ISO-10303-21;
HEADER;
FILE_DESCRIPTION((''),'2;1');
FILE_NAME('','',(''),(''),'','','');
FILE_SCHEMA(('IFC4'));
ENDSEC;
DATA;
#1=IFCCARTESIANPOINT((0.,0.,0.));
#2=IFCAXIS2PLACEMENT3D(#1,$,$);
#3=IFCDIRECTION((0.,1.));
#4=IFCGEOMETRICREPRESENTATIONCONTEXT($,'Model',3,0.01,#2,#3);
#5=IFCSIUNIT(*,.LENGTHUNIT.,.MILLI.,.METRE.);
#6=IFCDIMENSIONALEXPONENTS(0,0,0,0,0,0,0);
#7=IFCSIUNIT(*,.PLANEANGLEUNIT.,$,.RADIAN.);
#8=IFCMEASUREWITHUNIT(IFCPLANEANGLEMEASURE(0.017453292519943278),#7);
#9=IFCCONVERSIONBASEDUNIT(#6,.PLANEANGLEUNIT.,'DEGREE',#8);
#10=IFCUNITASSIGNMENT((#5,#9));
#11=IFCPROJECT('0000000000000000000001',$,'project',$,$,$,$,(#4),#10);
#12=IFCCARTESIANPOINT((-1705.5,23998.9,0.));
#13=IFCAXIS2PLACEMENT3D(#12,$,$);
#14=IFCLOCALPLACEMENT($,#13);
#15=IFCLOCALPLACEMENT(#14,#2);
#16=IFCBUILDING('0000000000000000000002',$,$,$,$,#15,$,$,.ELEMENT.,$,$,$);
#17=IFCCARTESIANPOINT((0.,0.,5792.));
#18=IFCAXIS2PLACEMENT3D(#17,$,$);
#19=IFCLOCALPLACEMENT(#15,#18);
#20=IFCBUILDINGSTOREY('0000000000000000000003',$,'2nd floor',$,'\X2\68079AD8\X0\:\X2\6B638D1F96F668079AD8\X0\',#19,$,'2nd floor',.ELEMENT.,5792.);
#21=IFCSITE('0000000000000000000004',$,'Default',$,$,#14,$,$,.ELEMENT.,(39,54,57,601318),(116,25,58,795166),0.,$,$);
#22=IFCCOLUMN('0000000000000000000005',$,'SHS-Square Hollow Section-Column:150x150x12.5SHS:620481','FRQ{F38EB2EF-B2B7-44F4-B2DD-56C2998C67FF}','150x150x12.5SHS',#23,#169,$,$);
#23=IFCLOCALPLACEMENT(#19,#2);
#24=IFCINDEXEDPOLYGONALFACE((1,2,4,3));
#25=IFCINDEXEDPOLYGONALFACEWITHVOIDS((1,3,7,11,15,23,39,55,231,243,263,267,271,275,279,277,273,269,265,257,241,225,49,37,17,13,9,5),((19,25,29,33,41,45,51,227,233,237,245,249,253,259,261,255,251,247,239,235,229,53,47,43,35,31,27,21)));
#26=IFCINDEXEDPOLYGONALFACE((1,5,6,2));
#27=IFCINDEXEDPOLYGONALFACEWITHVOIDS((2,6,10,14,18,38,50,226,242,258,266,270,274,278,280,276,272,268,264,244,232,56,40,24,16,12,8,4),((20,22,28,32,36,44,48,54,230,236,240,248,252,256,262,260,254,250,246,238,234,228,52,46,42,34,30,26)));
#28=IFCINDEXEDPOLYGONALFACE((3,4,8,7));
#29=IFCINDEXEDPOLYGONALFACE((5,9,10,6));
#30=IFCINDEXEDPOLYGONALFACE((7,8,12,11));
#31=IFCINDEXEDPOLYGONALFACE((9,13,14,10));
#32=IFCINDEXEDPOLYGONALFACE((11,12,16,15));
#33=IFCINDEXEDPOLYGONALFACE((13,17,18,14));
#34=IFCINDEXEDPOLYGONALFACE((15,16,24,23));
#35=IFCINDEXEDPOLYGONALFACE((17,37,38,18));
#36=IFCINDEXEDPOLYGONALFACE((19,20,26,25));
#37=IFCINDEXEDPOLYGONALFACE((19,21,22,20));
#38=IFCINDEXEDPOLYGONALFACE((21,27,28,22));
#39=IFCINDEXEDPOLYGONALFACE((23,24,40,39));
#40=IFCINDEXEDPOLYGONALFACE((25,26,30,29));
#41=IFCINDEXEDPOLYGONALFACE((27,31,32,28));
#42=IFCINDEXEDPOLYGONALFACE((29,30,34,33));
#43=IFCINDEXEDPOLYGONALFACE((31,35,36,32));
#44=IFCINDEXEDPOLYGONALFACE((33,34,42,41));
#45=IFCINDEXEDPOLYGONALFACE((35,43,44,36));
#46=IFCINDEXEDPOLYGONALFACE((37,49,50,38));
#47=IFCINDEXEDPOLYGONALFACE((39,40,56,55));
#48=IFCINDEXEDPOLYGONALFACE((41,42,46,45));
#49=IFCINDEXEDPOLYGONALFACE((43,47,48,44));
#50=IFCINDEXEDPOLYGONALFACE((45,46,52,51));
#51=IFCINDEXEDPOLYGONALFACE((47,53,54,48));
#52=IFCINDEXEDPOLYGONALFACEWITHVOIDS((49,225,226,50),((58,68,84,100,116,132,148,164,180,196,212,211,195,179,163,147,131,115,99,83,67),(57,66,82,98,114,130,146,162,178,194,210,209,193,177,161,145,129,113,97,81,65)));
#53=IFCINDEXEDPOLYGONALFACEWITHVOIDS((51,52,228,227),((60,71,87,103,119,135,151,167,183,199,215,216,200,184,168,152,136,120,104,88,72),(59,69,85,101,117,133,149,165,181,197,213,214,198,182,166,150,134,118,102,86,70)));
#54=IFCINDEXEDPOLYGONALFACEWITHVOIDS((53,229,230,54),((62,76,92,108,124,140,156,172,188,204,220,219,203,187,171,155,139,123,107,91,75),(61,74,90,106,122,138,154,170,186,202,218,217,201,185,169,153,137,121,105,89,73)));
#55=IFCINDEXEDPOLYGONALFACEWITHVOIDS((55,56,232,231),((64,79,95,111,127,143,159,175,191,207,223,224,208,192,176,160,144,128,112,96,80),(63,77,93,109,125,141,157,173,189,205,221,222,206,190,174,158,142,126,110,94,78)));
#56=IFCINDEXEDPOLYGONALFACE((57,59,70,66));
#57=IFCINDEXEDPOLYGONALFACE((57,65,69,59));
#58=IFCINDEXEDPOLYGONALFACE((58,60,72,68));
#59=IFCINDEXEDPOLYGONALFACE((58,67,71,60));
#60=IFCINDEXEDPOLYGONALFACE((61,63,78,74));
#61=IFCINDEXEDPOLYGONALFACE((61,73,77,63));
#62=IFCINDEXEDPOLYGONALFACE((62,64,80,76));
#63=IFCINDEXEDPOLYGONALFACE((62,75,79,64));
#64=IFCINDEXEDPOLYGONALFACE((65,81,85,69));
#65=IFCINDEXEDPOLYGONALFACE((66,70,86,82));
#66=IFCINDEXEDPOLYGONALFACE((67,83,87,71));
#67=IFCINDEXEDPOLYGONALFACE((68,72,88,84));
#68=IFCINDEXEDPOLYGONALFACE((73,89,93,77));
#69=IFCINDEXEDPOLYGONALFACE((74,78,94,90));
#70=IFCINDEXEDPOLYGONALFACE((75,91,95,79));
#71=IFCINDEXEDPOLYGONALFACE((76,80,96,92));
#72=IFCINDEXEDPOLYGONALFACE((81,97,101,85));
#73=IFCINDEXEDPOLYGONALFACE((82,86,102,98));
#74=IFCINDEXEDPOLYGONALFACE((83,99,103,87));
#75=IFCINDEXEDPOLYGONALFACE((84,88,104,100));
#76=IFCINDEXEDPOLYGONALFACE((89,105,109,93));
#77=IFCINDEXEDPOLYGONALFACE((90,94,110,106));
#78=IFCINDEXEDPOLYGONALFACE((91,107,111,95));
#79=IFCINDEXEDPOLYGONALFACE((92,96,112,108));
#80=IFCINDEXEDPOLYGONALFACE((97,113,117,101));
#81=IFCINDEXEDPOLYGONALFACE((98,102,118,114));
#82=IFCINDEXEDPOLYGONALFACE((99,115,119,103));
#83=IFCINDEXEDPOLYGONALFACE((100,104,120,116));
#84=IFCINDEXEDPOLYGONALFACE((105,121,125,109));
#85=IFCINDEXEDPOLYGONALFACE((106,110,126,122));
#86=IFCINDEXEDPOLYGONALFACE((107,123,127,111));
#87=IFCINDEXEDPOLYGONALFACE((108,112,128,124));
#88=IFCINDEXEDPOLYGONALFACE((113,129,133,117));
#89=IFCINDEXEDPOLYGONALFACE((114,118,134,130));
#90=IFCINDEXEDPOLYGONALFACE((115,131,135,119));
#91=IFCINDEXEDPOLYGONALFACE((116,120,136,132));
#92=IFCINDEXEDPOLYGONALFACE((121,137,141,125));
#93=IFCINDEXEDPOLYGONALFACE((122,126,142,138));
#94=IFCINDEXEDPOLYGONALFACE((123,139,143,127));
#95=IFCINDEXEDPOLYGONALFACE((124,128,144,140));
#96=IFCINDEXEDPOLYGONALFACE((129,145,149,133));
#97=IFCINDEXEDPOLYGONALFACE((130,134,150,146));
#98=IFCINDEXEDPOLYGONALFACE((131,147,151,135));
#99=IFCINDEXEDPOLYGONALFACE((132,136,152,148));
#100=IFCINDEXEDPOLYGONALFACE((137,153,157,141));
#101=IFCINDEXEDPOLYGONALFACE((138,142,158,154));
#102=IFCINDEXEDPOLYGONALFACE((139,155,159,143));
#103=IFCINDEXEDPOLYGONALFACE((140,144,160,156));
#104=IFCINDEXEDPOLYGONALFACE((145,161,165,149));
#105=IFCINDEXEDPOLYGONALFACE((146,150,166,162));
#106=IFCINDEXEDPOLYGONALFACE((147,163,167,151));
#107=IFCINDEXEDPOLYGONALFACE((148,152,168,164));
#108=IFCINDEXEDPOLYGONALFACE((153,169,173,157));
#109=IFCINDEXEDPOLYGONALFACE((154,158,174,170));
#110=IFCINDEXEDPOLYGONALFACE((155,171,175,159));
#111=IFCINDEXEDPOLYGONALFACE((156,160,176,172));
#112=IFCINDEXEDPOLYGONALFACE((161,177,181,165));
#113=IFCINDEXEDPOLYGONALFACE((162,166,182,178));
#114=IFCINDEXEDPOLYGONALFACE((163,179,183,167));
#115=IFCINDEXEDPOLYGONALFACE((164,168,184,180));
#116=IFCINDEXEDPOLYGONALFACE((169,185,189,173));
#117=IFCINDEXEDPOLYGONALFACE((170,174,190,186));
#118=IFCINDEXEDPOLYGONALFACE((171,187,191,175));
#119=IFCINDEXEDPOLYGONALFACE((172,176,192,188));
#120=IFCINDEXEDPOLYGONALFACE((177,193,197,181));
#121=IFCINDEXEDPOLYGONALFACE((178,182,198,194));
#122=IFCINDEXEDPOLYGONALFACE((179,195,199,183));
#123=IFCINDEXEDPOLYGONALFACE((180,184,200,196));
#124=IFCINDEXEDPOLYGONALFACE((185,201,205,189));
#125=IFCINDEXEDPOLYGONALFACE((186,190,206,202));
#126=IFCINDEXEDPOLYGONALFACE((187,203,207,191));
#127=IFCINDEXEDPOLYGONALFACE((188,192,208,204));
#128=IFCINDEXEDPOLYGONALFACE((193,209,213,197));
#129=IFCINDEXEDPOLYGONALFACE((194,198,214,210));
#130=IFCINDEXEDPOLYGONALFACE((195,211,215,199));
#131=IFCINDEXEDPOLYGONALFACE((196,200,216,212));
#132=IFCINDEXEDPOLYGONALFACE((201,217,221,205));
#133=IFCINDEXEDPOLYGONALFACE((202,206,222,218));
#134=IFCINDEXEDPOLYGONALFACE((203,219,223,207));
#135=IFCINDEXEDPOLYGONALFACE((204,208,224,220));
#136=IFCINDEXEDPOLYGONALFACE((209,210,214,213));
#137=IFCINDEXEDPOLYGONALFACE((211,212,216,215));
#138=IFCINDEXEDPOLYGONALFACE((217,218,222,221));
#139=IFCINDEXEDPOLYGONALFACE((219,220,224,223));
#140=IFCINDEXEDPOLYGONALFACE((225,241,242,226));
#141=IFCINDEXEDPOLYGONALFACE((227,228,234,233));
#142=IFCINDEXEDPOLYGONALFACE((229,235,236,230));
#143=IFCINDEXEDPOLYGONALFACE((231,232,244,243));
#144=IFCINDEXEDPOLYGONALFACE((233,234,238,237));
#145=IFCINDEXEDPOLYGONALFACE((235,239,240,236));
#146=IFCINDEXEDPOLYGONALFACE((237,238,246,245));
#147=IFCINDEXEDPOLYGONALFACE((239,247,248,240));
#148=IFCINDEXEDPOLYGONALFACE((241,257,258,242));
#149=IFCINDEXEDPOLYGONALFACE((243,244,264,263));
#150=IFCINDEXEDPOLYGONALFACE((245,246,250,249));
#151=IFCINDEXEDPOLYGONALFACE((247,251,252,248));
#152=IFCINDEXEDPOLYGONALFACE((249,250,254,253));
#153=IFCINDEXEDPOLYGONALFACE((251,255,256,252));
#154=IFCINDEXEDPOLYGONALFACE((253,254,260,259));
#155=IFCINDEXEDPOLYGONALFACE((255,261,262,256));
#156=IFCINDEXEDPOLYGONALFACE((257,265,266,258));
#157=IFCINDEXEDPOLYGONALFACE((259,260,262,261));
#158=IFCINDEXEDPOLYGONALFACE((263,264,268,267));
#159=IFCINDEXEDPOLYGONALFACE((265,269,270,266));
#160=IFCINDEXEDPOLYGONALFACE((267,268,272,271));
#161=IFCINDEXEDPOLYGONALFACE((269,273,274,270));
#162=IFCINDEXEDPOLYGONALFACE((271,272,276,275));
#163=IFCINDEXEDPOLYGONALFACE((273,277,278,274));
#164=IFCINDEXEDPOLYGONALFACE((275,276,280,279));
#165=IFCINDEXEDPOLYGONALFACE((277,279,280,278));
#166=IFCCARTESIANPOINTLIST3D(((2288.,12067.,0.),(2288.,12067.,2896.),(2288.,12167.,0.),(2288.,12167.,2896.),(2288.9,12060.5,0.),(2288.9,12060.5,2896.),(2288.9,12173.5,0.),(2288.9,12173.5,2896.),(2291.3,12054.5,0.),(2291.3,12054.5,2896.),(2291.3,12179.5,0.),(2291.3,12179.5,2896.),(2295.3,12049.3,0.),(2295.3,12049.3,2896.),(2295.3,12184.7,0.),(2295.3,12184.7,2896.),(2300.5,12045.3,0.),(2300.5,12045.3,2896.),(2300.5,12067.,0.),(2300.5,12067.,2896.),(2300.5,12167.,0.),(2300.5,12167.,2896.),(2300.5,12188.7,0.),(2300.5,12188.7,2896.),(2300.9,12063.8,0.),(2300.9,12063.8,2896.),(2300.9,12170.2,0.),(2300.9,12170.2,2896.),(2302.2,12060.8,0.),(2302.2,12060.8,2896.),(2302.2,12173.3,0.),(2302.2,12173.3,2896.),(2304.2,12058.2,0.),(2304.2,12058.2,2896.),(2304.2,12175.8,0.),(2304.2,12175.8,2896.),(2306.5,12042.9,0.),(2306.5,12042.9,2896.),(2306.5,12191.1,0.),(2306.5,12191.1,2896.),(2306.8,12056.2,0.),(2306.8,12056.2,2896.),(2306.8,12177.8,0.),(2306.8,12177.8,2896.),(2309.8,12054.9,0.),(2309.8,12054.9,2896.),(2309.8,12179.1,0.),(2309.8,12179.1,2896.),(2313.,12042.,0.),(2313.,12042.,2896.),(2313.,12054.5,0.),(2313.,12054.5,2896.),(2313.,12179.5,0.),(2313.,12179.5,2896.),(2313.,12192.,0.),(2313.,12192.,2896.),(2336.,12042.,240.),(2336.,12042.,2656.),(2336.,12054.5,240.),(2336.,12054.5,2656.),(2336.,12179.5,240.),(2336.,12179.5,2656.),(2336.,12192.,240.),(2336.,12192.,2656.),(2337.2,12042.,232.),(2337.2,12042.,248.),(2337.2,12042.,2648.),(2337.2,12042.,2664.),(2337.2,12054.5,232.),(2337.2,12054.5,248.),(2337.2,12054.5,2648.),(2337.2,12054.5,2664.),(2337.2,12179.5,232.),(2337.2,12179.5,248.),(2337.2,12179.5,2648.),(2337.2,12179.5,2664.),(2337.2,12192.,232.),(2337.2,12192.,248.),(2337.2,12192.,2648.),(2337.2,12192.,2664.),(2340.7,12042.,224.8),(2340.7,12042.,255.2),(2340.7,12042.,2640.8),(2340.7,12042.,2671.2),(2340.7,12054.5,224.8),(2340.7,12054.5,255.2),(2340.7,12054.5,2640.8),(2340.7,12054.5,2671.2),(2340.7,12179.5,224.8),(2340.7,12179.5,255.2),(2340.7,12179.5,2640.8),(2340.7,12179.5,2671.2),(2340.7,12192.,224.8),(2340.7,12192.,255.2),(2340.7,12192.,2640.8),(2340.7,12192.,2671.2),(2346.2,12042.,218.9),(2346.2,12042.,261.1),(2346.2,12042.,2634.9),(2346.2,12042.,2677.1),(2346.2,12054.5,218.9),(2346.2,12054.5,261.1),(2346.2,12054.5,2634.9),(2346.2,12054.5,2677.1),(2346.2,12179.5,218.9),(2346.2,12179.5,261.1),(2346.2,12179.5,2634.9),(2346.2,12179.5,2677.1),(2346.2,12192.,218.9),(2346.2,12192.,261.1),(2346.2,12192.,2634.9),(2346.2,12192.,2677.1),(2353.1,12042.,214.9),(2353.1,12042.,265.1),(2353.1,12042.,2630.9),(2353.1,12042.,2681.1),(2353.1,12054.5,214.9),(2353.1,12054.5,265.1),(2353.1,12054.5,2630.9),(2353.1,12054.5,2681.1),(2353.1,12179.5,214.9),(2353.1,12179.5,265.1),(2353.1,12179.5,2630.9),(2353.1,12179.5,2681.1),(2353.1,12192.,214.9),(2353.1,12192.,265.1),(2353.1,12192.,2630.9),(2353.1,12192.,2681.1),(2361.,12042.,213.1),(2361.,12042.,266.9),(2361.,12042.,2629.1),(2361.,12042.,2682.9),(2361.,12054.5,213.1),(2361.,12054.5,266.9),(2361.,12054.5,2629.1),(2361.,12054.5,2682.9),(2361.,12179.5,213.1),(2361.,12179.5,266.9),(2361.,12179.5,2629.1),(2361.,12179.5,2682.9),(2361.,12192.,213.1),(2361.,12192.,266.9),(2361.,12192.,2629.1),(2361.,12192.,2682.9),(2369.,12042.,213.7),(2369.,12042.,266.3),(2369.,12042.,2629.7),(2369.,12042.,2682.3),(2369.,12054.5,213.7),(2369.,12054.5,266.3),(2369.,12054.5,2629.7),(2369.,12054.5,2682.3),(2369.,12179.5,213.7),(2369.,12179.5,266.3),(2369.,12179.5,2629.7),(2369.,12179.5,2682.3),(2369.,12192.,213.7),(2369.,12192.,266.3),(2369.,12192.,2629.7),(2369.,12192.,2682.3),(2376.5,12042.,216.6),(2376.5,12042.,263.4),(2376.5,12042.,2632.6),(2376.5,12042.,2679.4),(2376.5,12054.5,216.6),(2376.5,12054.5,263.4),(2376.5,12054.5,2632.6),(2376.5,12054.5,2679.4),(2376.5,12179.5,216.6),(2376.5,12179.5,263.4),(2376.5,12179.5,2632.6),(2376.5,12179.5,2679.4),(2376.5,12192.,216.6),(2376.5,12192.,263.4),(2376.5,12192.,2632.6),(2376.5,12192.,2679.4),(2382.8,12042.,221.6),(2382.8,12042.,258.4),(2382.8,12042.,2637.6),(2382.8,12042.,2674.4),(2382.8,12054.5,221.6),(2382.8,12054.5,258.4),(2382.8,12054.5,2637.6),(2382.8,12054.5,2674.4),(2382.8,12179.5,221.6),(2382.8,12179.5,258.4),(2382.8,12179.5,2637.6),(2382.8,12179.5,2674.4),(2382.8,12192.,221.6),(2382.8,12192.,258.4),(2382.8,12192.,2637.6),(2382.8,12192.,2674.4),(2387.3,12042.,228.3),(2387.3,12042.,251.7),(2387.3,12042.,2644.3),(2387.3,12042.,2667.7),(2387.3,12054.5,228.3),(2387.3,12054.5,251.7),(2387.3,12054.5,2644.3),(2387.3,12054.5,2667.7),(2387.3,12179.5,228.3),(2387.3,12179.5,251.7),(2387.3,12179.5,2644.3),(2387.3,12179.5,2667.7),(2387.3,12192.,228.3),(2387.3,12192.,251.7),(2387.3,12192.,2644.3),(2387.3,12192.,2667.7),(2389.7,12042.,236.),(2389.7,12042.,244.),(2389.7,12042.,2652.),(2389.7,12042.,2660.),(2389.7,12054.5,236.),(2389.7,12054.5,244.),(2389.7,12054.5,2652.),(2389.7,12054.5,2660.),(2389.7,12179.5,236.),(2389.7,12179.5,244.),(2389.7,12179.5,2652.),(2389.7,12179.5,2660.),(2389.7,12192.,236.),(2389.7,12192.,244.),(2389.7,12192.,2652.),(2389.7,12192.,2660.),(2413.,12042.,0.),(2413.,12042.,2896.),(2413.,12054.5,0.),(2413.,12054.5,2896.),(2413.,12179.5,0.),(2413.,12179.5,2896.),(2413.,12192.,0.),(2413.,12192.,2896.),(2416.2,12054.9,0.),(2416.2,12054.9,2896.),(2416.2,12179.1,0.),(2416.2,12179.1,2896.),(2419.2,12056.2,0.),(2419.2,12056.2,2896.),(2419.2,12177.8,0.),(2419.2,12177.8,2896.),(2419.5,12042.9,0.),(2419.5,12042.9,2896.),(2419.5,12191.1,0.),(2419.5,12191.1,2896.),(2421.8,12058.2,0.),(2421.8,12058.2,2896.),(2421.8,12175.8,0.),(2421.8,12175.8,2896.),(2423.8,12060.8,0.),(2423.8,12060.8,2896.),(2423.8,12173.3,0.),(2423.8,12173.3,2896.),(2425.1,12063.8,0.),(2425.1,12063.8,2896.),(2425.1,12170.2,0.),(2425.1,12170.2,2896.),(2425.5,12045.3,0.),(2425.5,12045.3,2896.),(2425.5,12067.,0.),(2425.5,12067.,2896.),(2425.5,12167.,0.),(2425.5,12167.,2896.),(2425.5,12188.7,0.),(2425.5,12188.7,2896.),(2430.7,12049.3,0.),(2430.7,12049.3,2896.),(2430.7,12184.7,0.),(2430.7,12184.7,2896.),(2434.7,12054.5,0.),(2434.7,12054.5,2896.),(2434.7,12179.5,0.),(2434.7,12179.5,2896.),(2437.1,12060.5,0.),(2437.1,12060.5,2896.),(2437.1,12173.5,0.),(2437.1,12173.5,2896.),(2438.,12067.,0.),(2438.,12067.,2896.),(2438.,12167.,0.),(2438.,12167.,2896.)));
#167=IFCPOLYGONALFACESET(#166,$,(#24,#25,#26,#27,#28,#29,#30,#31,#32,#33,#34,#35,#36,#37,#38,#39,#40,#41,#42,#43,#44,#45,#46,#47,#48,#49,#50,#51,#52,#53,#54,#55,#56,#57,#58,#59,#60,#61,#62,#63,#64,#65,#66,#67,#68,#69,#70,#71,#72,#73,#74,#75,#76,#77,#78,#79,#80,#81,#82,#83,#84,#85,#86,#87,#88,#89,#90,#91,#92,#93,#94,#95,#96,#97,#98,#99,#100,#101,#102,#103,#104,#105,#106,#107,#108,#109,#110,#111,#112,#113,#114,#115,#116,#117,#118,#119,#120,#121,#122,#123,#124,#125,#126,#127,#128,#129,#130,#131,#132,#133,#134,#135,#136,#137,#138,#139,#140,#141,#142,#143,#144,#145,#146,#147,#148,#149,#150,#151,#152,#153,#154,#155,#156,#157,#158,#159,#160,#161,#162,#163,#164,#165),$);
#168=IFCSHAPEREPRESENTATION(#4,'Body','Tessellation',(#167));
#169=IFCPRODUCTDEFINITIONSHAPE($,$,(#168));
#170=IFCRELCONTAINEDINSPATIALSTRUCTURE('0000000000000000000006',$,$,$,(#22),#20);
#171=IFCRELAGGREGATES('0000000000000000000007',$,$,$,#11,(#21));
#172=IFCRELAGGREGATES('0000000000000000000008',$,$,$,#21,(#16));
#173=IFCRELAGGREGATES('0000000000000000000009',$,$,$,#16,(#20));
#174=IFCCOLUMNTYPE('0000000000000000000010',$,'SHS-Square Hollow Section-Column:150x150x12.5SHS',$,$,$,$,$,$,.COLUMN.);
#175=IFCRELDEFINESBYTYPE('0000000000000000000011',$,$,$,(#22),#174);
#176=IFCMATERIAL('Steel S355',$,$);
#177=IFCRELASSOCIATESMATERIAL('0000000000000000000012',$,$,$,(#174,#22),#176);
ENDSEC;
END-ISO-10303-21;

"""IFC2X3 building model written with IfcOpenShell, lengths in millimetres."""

from ifc_helpers import new_model, entity, si_unit, converted_unit, direction, frame, frame_2d, origin, origin_2d, place, context, project, spatial, circle_curve, hollow_rectangle, outline, extrude, material, type_object, element, save


model = new_model("IFC2X3")

# Units and contexts
model_context = context("Model", 3, precision=0.01, world=origin(), true_north=direction((0.0, 1.0)))
ifc_project = project(units=[si_unit("LENGTHUNIT", "METRE", prefix="MILLI"), converted_unit("PLANEANGLEUNIT", "DEGREE", entity("IfcPlaneAngleMeasure", 0.017453292519943278), si_unit("PLANEANGLEUNIT", "RADIAN"), dimensions=[0, 0, 0, 0, 0, 0, 0])], contexts=[model_context])

# Site, building, storey
site_placement = place(None, frame((-1705.5, 23998.9, 0.0)))
site = spatial("IfcSite", under=ifc_project, at=site_placement, Name="Default", CompositionType="ELEMENT", RefLatitude=(39, 54, 57, 601318), RefLongitude=(116, 25, 58, 795166), RefElevation=0.0)
building_placement = place(site_placement, origin())
building = spatial("IfcBuilding", under=site, at=building_placement, CompositionType="ELEMENT")
storey_placement = place(building_placement, frame((0.0, 0.0, 5792.0)))
storey = spatial("IfcBuildingStorey", under=building, at=storey_placement, Name="2nd floor", ObjectType="标高:正负零标高", LongName="2nd floor", CompositionType="ELEMENT", Elevation=5792.0)

# Column, openings
ifc_material_1 = material(Name="Steel S355")
column_type_1 = type_object("IfcColumnType", Name="SHS-Square Hollow Section-Column:150x150x12.5SHS", PredefinedType="COLUMN", material=ifc_material_1)
column_1_placement = place(storey_placement, frame((2363.0, 12117.0, 2896.0), z_axis=(0.0, 0.0, 1.0), x_axis=(0.0, -1.0, 0.0)))
column_1 = element("IfcColumn", 1, at=column_1_placement, inside=storey, type_object=column_type_1, material=ifc_material_1, Name="SHS-Square Hollow Section-Column:150x150x12.5SHS:620481", Description="FRQ{F38EB2EF-B2B7-44F4-B2DD-56C2998C67FF}", ObjectType="150x150x12.5SHS", context=model_context, shape_type="SweptSolid", body=[
    extrude(hollow_rectangle(XDim=150.0, YDim=150.0, WallThickness=12.5, InnerFilletRadius=12.5, OuterFilletRadius=25.0, at=origin_2d()), origin(), (0.0, 0.0, -1.0), 2896.0),
])
opening_1_placement = place(column_1_placement, frame((175.1, 0.0, 0.0), z_axis=(-1.0, 0.0, 0.0), x_axis=(0.0, -1.0, 0.0)))
element("IfcOpeningElement", 2, at=opening_1_placement, cuts=column_1, ObjectType="Opening", context=model_context, shape_type="SweptSolid", body=[
    extrude(outline(circle_curve(frame_2d((0.0, -240.0), x_axis=(1.0, 0.0)), 27.0)), origin(), (0.0, 0.0, 1.0), 350.2),
])
opening_2_placement = place(column_1_placement, frame((175.1, 0.0, -2896.0), z_axis=(-1.0, 0.0, 0.0), x_axis=(0.0, -1.0, 0.0)))
element("IfcOpeningElement", 3, at=opening_2_placement, cuts=column_1, ObjectType="Opening", context=model_context, shape_type="SweptSolid", body=[
    extrude(outline(circle_curve(frame_2d((0.0, 240.0), x_axis=(1.0, 0.0)), 27.0)), origin(), (0.0, 0.0, 1.0), 350.2),
])

save(model, "model.ifc")
